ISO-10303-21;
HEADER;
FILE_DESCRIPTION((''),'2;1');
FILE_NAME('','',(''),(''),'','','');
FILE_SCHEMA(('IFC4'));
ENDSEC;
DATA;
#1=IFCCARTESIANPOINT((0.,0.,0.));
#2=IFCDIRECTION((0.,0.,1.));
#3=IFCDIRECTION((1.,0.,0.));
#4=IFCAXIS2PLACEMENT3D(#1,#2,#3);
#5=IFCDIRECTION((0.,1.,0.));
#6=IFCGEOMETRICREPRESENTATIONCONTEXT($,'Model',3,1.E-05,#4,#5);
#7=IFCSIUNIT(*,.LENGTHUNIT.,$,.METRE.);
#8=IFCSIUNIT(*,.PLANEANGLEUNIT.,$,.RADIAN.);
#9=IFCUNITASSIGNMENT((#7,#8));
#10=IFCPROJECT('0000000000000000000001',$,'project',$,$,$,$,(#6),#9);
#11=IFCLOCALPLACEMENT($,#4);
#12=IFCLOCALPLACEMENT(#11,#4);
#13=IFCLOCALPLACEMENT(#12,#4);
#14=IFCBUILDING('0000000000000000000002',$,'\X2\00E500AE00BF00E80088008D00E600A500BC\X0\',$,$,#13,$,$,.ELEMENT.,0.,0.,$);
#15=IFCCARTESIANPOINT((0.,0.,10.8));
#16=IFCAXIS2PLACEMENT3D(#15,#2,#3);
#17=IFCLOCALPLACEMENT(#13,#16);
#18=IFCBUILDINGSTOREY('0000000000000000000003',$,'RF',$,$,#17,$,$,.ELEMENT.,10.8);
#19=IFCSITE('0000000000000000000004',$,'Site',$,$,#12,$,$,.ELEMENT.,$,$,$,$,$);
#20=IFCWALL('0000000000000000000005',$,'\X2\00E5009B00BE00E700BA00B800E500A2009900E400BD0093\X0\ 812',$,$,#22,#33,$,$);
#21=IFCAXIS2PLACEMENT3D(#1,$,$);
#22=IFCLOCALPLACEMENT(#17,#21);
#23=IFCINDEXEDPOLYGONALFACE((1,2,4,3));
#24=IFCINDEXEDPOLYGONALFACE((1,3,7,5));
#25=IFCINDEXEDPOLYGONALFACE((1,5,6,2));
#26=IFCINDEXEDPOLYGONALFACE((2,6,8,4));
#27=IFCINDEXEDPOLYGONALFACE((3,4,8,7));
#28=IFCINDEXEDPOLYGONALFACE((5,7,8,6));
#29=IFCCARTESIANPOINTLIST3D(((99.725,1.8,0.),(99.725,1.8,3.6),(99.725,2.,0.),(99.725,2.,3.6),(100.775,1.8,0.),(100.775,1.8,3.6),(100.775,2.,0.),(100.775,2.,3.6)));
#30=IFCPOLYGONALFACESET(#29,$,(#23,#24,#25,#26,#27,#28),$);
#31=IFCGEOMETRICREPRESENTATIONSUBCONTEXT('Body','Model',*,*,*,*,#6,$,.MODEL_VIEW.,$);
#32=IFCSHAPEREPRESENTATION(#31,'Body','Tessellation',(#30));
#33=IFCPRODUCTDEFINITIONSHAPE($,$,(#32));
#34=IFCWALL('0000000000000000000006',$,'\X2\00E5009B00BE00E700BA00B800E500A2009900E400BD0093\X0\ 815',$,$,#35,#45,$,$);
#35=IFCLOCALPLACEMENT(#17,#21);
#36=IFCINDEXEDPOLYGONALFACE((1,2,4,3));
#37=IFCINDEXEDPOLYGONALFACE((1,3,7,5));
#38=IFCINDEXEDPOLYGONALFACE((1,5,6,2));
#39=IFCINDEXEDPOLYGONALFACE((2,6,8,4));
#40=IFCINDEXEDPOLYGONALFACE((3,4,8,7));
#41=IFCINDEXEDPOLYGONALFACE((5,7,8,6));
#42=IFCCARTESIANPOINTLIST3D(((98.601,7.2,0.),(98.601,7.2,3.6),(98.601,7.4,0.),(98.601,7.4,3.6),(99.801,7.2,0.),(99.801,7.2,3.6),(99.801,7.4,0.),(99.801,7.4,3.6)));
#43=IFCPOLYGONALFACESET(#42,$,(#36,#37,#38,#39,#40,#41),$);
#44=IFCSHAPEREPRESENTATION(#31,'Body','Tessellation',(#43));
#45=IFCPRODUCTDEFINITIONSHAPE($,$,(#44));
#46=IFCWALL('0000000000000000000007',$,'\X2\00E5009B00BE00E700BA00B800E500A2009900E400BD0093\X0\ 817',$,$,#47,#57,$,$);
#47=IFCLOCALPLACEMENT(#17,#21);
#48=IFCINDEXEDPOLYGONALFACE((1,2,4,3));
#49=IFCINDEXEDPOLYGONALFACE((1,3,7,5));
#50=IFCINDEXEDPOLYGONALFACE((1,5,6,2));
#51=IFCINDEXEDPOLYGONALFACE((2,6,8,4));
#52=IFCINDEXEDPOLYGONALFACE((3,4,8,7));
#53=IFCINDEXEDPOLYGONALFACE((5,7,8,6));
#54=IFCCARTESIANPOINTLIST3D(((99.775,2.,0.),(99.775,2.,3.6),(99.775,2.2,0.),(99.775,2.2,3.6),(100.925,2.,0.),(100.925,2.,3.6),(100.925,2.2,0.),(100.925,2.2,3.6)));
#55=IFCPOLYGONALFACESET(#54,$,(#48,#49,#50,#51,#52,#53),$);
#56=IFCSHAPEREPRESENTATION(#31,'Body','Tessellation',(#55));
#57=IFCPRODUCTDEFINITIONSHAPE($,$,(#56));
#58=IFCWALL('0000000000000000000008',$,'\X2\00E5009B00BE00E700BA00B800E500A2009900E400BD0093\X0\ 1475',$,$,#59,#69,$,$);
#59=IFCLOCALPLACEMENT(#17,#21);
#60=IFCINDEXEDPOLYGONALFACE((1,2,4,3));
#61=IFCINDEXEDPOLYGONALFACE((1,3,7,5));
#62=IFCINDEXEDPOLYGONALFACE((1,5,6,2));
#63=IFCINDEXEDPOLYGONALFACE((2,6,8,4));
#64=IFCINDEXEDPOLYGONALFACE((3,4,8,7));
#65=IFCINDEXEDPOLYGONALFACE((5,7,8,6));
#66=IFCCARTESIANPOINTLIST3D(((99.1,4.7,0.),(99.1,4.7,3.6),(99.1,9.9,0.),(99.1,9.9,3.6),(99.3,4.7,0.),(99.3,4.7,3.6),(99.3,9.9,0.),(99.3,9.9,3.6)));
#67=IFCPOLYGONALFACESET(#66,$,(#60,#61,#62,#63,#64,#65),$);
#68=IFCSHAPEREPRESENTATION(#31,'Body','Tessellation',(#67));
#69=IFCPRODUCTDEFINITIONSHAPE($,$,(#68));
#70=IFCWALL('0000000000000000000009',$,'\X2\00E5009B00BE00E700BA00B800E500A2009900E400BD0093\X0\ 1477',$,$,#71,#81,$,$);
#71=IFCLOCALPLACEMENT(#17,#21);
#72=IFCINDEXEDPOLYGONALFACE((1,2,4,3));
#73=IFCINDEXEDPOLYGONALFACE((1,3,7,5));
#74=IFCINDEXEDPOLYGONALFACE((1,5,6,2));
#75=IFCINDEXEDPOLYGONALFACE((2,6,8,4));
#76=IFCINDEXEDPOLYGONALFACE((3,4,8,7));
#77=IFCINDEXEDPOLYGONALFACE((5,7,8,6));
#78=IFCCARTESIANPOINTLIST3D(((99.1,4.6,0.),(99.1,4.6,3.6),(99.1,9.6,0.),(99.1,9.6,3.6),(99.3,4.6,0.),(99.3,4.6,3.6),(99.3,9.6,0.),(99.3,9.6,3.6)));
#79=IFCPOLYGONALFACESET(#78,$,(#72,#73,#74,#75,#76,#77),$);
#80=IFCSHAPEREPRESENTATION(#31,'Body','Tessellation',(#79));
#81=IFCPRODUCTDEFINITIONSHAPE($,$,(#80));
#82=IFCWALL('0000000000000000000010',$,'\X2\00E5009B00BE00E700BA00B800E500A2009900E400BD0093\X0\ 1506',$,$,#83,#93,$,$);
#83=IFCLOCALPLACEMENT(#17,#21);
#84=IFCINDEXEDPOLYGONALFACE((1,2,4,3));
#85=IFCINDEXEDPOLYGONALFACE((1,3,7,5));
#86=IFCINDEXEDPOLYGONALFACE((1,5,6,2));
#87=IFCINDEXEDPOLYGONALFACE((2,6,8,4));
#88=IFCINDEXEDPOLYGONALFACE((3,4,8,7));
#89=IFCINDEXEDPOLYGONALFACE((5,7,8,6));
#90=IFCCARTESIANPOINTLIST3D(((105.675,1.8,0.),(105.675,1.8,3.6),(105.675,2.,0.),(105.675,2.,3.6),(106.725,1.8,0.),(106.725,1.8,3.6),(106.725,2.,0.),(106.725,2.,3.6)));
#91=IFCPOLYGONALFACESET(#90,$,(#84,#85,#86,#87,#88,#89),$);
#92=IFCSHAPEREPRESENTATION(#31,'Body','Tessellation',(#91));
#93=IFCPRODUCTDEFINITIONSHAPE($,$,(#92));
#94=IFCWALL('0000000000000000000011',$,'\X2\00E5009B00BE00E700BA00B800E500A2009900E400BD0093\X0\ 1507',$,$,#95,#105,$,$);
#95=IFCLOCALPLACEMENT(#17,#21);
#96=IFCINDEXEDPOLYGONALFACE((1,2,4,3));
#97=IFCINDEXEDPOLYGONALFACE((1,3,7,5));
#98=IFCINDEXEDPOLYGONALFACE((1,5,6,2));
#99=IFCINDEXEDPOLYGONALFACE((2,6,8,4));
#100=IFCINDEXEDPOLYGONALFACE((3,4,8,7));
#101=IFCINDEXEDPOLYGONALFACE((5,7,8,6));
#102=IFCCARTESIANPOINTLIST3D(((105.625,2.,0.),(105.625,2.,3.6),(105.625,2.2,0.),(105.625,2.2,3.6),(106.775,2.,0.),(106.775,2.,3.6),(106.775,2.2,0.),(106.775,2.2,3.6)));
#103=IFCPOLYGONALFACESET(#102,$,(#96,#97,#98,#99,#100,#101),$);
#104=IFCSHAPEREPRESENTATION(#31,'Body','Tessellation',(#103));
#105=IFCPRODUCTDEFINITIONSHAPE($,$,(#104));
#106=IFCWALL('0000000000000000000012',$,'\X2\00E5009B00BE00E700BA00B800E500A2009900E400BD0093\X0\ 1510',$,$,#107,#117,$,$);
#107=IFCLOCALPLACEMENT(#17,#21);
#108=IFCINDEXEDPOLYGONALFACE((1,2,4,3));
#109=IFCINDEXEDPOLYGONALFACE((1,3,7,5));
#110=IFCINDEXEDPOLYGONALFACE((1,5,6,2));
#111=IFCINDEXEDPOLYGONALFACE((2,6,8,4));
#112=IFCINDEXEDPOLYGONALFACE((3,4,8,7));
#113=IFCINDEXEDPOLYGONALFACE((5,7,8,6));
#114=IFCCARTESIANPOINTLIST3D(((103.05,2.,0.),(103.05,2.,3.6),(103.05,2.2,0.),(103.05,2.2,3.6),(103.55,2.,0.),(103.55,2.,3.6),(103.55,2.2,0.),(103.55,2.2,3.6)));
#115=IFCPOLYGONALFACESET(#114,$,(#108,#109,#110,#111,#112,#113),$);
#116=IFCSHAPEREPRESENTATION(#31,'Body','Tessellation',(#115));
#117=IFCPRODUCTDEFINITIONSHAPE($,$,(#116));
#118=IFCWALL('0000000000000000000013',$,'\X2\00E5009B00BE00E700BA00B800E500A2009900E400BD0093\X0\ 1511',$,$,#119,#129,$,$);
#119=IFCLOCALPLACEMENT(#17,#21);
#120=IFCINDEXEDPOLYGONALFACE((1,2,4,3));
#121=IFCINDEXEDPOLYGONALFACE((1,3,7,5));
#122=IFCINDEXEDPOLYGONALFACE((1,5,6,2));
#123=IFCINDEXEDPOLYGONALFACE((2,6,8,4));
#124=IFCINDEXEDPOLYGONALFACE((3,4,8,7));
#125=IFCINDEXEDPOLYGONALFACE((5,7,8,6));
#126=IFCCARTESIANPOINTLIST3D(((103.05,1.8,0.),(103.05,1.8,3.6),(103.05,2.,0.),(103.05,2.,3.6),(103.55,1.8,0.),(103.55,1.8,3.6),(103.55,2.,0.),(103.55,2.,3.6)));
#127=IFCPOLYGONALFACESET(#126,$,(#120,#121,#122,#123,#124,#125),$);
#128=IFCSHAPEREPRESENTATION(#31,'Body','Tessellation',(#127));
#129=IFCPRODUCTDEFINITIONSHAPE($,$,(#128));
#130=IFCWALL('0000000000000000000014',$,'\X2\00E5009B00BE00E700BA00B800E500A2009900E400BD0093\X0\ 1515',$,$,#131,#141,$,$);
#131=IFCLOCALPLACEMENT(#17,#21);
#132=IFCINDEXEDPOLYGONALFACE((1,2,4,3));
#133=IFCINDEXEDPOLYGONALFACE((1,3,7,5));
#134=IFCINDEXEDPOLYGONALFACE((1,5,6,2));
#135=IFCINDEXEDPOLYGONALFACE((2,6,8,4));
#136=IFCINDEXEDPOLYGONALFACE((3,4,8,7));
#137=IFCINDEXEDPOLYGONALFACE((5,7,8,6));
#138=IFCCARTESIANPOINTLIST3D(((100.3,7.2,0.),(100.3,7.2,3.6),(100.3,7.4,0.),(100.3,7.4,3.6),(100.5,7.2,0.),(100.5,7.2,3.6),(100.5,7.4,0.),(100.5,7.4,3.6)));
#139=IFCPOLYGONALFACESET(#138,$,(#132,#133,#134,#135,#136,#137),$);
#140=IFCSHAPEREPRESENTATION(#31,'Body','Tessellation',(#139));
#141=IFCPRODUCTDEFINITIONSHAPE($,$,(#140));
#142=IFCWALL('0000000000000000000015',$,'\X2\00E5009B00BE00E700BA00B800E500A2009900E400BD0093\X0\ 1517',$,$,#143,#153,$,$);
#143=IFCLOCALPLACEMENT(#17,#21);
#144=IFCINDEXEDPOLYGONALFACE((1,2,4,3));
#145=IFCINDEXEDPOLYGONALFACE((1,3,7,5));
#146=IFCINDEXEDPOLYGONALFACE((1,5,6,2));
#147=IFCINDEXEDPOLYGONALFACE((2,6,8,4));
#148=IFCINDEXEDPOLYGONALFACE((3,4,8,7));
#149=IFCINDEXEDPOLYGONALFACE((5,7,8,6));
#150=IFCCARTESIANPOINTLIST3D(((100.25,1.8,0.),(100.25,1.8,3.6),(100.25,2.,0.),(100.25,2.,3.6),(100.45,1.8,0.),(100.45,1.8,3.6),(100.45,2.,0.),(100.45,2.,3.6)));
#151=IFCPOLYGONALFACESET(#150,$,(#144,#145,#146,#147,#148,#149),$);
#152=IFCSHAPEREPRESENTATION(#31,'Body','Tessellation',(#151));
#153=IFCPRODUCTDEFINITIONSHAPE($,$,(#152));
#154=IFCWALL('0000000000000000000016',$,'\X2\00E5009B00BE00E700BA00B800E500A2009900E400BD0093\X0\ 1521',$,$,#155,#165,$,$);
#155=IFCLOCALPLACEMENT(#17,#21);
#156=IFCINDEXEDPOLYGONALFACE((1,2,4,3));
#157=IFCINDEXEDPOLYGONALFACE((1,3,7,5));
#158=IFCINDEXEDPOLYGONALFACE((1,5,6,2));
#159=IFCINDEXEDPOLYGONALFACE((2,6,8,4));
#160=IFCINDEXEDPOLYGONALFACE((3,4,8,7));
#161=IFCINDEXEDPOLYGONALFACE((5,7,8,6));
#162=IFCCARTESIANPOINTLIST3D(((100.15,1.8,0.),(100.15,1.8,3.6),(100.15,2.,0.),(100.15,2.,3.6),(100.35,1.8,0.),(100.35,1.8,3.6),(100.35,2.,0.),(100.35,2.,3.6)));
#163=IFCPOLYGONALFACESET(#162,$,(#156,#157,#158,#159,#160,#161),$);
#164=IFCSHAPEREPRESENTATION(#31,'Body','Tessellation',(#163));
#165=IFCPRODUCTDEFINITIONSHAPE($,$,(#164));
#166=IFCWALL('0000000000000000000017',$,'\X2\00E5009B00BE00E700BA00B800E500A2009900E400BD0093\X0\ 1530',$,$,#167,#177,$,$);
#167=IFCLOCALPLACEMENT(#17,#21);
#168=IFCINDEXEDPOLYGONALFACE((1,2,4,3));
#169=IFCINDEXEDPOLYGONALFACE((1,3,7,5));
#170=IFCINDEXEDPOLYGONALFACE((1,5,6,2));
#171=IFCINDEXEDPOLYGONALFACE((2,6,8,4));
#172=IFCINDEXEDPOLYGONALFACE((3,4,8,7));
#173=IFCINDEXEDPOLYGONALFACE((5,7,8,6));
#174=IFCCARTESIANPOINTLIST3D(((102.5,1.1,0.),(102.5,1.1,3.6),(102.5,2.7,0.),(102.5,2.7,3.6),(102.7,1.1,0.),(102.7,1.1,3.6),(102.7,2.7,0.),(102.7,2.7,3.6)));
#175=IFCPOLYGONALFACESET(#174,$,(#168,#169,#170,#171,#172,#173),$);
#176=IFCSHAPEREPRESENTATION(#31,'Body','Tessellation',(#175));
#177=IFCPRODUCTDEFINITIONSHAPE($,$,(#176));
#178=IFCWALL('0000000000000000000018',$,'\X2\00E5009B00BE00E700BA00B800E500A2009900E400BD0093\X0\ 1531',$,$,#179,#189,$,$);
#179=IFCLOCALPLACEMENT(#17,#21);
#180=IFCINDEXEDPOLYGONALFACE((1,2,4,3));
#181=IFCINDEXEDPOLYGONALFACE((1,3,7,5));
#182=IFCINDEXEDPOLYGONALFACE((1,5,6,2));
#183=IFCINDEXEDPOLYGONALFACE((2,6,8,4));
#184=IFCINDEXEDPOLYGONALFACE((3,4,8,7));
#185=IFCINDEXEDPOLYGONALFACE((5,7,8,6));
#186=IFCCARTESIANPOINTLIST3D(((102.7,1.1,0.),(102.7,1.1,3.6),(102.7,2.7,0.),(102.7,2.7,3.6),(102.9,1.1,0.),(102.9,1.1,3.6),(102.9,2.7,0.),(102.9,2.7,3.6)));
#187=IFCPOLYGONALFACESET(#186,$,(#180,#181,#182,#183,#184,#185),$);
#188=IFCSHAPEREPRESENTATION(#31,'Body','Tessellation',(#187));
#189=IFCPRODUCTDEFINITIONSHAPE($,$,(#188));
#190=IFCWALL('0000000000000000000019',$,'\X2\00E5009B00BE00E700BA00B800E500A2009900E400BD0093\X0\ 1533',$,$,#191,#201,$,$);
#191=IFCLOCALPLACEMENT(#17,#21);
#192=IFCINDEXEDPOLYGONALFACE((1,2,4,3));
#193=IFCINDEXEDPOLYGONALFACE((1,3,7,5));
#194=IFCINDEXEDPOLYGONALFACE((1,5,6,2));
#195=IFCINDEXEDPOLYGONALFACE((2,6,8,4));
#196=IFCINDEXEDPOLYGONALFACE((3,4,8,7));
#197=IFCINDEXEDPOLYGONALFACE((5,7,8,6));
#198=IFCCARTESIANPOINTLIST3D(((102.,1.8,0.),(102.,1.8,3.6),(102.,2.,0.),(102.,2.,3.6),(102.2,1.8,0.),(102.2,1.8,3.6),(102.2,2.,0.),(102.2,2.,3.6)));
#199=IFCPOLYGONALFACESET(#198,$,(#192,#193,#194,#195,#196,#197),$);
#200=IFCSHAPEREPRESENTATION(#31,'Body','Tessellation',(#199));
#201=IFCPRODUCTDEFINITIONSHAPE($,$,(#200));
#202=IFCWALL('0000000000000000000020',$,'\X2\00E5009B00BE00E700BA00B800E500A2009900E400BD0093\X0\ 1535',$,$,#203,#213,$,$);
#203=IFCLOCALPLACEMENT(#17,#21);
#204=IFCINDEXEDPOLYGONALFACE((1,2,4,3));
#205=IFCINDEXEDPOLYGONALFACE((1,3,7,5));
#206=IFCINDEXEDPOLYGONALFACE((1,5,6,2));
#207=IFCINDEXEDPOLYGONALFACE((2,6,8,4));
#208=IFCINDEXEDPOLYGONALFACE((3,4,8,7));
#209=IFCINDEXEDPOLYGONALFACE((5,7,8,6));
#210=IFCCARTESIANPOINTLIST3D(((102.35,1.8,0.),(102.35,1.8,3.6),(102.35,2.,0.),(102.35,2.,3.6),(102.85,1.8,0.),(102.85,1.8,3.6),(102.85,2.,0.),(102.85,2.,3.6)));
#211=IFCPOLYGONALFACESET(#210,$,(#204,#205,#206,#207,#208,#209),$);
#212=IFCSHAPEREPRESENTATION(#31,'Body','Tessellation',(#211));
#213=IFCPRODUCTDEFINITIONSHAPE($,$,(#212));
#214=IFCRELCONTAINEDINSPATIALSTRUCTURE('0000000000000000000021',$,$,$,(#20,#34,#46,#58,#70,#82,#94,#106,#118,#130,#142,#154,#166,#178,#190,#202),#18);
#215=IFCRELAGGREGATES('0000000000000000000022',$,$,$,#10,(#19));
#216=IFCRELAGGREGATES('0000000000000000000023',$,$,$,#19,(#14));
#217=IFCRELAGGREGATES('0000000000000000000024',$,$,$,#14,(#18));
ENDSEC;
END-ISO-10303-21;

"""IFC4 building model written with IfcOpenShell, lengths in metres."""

from ifc_helpers import new_model, si_unit, direction, frame, frame_2d, origin_with_axes, place, context, subcontext, project, spatial, rectangle, extrude, element, save


model = new_model("IFC4")

# Units and contexts
model_context = context("Model", 3, precision=1e-05, world=origin_with_axes(), true_north=direction((0.0, 1.0, 0.0)))
body_context = subcontext(model_context, "Body", "Model", "MODEL_VIEW")
ifc_project = project(units=[si_unit("LENGTHUNIT", "METRE"), si_unit("PLANEANGLEUNIT", "RADIAN")], contexts=[model_context])

# Site, building, storey
placement = place(None, origin_with_axes())
site_placement = place(placement, origin_with_axes())
site = spatial("IfcSite", under=ifc_project, at=site_placement, Name="Site", CompositionType="ELEMENT")
building_placement = place(site_placement, origin_with_axes())
building = spatial("IfcBuilding", under=site, at=building_placement, Name="å®¿è\u0088\u008dæ¥¼", CompositionType="ELEMENT", ElevationOfRefHeight=0.0, ElevationOfTerrain=0.0)
storey_placement = place(building_placement, frame((0.0, 0.0, 10.8), z_axis=(0.0, 0.0, 1.0), x_axis=(1.0, 0.0, 0.0)))
storey = spatial("IfcBuildingStorey", under=building, at=storey_placement, Name="RF", CompositionType="ELEMENT", Elevation=10.8)

# Walls
wall_1_placement = place(storey_placement, frame((100.25, 1.9, 0.0), z_axis=(0.0, 0.0, 1.0), x_axis=(-1.0, 0.0, 0.0)))
element("IfcWall", 1, at=wall_1_placement, inside=storey, Name="å\u009b¾çº¸å¢\u0099ä½\u0093 812", context=body_context, shape_type="SweptSolid", body=[
    extrude(rectangle(XDim=1.05, YDim=0.2, at=frame_2d((0.0, 0.0), x_axis=(1.0, 0.0, 0.0))), frame((0.0, 0.0, 0.0), z_axis=(0.0, 0.0, 1.0)), (0.0, 0.0, 1.0), 3.6),
])
wall_2_placement = place(storey_placement, frame((99.201, 7.3, 0.0), z_axis=(0.0, 0.0, 1.0), x_axis=(1.0, 0.0, 0.0)))
element("IfcWall", 2, at=wall_2_placement, inside=storey, Name="å\u009b¾çº¸å¢\u0099ä½\u0093 815", context=body_context, shape_type="SweptSolid", body=[
    extrude(rectangle(XDim=1.2, YDim=0.2, at=frame_2d((0.0, 0.0), x_axis=(1.0, 0.0, 0.0))), frame((0.0, 0.0, 0.0), z_axis=(0.0, 0.0, 1.0)), (0.0, 0.0, 1.0), 3.6),
])
wall_3_placement = place(storey_placement, frame((100.35, 2.1, 0.0), z_axis=(0.0, 0.0, 1.0), x_axis=(-1.0, 0.0, 0.0)))
element("IfcWall", 3, at=wall_3_placement, inside=storey, Name="å\u009b¾çº¸å¢\u0099ä½\u0093 817", context=body_context, shape_type="SweptSolid", body=[
    extrude(rectangle(XDim=1.15, YDim=0.2, at=frame_2d((0.0, 0.0), x_axis=(1.0, 0.0, 0.0))), frame((0.0, 0.0, 0.0), z_axis=(0.0, 0.0, 1.0)), (0.0, 0.0, 1.0), 3.6),
])
wall_4_placement = place(storey_placement, frame((99.2, 7.3, 0.0), z_axis=(0.0, 0.0, 1.0), x_axis=(0.0, -1.0, 0.0)))
element("IfcWall", 4, at=wall_4_placement, inside=storey, Name="å\u009b¾çº¸å¢\u0099ä½\u0093 1475", context=body_context, shape_type="SweptSolid", body=[
    extrude(rectangle(XDim=5.2, YDim=0.2, at=frame_2d((0.0, 0.0), x_axis=(1.0, 0.0, 0.0))), frame((0.0, 0.0, 0.0), z_axis=(0.0, 0.0, 1.0)), (0.0, 0.0, 1.0), 3.6),
])
wall_5_placement = place(storey_placement, frame((99.2, 7.1, 0.0), z_axis=(0.0, 0.0, 1.0), x_axis=(0.0, -1.0, 0.0)))
element("IfcWall", 5, at=wall_5_placement, inside=storey, Name="å\u009b¾çº¸å¢\u0099ä½\u0093 1477", context=body_context, shape_type="SweptSolid", body=[
    extrude(rectangle(XDim=5.0, YDim=0.2, at=frame_2d((0.0, 0.0), x_axis=(1.0, 0.0, 0.0))), frame((0.0, 0.0, 0.0), z_axis=(0.0, 0.0, 1.0)), (0.0, 0.0, 1.0), 3.6),
])
wall_6_placement = place(storey_placement, frame((106.2, 1.9, 0.0), z_axis=(0.0, 0.0, 1.0), x_axis=(-1.0, 0.0, 0.0)))
element("IfcWall", 6, at=wall_6_placement, inside=storey, Name="å\u009b¾çº¸å¢\u0099ä½\u0093 1506", context=body_context, shape_type="SweptSolid", body=[
    extrude(rectangle(XDim=1.05, YDim=0.2, at=frame_2d((0.0, 0.0), x_axis=(1.0, 0.0, 0.0))), frame((0.0, 0.0, 0.0), z_axis=(0.0, 0.0, 1.0)), (0.0, 0.0, 1.0), 3.6),
])
wall_7_placement = place(storey_placement, frame((106.2, 2.1, 0.0), z_axis=(0.0, 0.0, 1.0), x_axis=(-1.0, 0.0, 0.0)))
element("IfcWall", 7, at=wall_7_placement, inside=storey, Name="å\u009b¾çº¸å¢\u0099ä½\u0093 1507", context=body_context, shape_type="SweptSolid", body=[
    extrude(rectangle(XDim=1.15, YDim=0.2, at=frame_2d((0.0, 0.0), x_axis=(1.0, 0.0, 0.0))), frame((0.0, 0.0, 0.0), z_axis=(0.0, 0.0, 1.0)), (0.0, 0.0, 1.0), 3.6),
])
for number, where, z_axis, x_axis, name in (
    (8, (103.3, 2.1, 0.0), (0.0, 0.0, 1.0), (-1.0, 0.0, 0.0), "å\u009b¾çº¸å¢\u0099ä½\u0093 1510"),
    (9, (103.3, 1.9, 0.0), (0.0, 0.0, 1.0), (-1.0, 0.0, 0.0), "å\u009b¾çº¸å¢\u0099ä½\u0093 1511"),
):
    element("IfcWall", number, at=place(storey_placement, frame(where, z_axis=z_axis, x_axis=x_axis)), inside=storey, Name=name, context=body_context, shape_type="SweptSolid", body=[
        extrude(rectangle(XDim=0.5, YDim=0.2, at=frame_2d((0.0, 0.0), x_axis=(1.0, 0.0, 0.0))), frame((0.0, 0.0, 0.0), z_axis=(0.0, 0.0, 1.0)), (0.0, 0.0, 1.0), 3.6),
    ])
for number, where, z_axis, x_axis, name in (
    (10, (100.4, 7.3, 0.0), (0.0, 0.0, 1.0), (0.0, 1.0, 0.0), "å\u009b¾çº¸å¢\u0099ä½\u0093 1515"),
    (11, (100.35, 1.9, 0.0), (0.0, 0.0, 1.0), (0.0, 1.0, 0.0), "å\u009b¾çº¸å¢\u0099ä½\u0093 1517"),
    (12, (100.25, 1.9, 0.0), (0.0, 0.0, 1.0), (0.0, -1.0, 0.0), "å\u009b¾çº¸å¢\u0099ä½\u0093 1521"),
):
    element("IfcWall", number, at=place(storey_placement, frame(where, z_axis=z_axis, x_axis=x_axis)), inside=storey, Name=name, context=body_context, shape_type="SweptSolid", body=[
        extrude(rectangle(XDim=0.2, YDim=0.2, at=frame_2d((0.0, 0.0), x_axis=(1.0, 0.0, 0.0))), frame((0.0, 0.0, 0.0), z_axis=(0.0, 0.0, 1.0)), (0.0, 0.0, 1.0), 3.6),
    ])
for number, where, z_axis, x_axis, name in (
    (13, (102.6, 1.9, 0.0), (0.0, 0.0, 1.0), (0.0, -1.0, 0.0), "å\u009b¾çº¸å¢\u0099ä½\u0093 1530"),
    (14, (102.8, 1.9, 0.0), (0.0, 0.0, 1.0), (0.0, -1.0, 0.0), "å\u009b¾çº¸å¢\u0099ä½\u0093 1531"),
):
    element("IfcWall", number, at=place(storey_placement, frame(where, z_axis=z_axis, x_axis=x_axis)), inside=storey, Name=name, context=body_context, shape_type="SweptSolid", body=[
        extrude(rectangle(XDim=1.6, YDim=0.2, at=frame_2d((0.0, 0.0), x_axis=(1.0, 0.0, 0.0))), frame((0.0, 0.0, 0.0), z_axis=(0.0, 0.0, 1.0)), (0.0, 0.0, 1.0), 3.6),
    ])
wall_8_placement = place(storey_placement, frame((102.1, 1.9, 0.0), z_axis=(0.0, 0.0, 1.0), x_axis=(0.0, 1.0, 0.0)))
element("IfcWall", 15, at=wall_8_placement, inside=storey, Name="å\u009b¾çº¸å¢\u0099ä½\u0093 1533", context=body_context, shape_type="SweptSolid", body=[
    extrude(rectangle(XDim=0.2, YDim=0.2, at=frame_2d((0.0, 0.0), x_axis=(1.0, 0.0, 0.0))), frame((0.0, 0.0, 0.0), z_axis=(0.0, 0.0, 1.0)), (0.0, 0.0, 1.0), 3.6),
])
for number, where, z_axis, x_axis, name in (
    (16, (102.6, 1.9, 0.0), (0.0, 0.0, 1.0), (-1.0, 0.0, 0.0), "å\u009b¾çº¸å¢\u0099ä½\u0093 1535"),
):
    element("IfcWall", number, at=place(storey_placement, frame(where, z_axis=z_axis, x_axis=x_axis)), inside=storey, Name=name, context=body_context, shape_type="SweptSolid", body=[
        extrude(rectangle(XDim=0.5, YDim=0.2, at=frame_2d((0.0, 0.0), x_axis=(1.0, 0.0, 0.0))), frame((0.0, 0.0, 0.0), z_axis=(0.0, 0.0, 1.0)), (0.0, 0.0, 1.0), 3.6),
    ])

save(model, "model.ifc")
